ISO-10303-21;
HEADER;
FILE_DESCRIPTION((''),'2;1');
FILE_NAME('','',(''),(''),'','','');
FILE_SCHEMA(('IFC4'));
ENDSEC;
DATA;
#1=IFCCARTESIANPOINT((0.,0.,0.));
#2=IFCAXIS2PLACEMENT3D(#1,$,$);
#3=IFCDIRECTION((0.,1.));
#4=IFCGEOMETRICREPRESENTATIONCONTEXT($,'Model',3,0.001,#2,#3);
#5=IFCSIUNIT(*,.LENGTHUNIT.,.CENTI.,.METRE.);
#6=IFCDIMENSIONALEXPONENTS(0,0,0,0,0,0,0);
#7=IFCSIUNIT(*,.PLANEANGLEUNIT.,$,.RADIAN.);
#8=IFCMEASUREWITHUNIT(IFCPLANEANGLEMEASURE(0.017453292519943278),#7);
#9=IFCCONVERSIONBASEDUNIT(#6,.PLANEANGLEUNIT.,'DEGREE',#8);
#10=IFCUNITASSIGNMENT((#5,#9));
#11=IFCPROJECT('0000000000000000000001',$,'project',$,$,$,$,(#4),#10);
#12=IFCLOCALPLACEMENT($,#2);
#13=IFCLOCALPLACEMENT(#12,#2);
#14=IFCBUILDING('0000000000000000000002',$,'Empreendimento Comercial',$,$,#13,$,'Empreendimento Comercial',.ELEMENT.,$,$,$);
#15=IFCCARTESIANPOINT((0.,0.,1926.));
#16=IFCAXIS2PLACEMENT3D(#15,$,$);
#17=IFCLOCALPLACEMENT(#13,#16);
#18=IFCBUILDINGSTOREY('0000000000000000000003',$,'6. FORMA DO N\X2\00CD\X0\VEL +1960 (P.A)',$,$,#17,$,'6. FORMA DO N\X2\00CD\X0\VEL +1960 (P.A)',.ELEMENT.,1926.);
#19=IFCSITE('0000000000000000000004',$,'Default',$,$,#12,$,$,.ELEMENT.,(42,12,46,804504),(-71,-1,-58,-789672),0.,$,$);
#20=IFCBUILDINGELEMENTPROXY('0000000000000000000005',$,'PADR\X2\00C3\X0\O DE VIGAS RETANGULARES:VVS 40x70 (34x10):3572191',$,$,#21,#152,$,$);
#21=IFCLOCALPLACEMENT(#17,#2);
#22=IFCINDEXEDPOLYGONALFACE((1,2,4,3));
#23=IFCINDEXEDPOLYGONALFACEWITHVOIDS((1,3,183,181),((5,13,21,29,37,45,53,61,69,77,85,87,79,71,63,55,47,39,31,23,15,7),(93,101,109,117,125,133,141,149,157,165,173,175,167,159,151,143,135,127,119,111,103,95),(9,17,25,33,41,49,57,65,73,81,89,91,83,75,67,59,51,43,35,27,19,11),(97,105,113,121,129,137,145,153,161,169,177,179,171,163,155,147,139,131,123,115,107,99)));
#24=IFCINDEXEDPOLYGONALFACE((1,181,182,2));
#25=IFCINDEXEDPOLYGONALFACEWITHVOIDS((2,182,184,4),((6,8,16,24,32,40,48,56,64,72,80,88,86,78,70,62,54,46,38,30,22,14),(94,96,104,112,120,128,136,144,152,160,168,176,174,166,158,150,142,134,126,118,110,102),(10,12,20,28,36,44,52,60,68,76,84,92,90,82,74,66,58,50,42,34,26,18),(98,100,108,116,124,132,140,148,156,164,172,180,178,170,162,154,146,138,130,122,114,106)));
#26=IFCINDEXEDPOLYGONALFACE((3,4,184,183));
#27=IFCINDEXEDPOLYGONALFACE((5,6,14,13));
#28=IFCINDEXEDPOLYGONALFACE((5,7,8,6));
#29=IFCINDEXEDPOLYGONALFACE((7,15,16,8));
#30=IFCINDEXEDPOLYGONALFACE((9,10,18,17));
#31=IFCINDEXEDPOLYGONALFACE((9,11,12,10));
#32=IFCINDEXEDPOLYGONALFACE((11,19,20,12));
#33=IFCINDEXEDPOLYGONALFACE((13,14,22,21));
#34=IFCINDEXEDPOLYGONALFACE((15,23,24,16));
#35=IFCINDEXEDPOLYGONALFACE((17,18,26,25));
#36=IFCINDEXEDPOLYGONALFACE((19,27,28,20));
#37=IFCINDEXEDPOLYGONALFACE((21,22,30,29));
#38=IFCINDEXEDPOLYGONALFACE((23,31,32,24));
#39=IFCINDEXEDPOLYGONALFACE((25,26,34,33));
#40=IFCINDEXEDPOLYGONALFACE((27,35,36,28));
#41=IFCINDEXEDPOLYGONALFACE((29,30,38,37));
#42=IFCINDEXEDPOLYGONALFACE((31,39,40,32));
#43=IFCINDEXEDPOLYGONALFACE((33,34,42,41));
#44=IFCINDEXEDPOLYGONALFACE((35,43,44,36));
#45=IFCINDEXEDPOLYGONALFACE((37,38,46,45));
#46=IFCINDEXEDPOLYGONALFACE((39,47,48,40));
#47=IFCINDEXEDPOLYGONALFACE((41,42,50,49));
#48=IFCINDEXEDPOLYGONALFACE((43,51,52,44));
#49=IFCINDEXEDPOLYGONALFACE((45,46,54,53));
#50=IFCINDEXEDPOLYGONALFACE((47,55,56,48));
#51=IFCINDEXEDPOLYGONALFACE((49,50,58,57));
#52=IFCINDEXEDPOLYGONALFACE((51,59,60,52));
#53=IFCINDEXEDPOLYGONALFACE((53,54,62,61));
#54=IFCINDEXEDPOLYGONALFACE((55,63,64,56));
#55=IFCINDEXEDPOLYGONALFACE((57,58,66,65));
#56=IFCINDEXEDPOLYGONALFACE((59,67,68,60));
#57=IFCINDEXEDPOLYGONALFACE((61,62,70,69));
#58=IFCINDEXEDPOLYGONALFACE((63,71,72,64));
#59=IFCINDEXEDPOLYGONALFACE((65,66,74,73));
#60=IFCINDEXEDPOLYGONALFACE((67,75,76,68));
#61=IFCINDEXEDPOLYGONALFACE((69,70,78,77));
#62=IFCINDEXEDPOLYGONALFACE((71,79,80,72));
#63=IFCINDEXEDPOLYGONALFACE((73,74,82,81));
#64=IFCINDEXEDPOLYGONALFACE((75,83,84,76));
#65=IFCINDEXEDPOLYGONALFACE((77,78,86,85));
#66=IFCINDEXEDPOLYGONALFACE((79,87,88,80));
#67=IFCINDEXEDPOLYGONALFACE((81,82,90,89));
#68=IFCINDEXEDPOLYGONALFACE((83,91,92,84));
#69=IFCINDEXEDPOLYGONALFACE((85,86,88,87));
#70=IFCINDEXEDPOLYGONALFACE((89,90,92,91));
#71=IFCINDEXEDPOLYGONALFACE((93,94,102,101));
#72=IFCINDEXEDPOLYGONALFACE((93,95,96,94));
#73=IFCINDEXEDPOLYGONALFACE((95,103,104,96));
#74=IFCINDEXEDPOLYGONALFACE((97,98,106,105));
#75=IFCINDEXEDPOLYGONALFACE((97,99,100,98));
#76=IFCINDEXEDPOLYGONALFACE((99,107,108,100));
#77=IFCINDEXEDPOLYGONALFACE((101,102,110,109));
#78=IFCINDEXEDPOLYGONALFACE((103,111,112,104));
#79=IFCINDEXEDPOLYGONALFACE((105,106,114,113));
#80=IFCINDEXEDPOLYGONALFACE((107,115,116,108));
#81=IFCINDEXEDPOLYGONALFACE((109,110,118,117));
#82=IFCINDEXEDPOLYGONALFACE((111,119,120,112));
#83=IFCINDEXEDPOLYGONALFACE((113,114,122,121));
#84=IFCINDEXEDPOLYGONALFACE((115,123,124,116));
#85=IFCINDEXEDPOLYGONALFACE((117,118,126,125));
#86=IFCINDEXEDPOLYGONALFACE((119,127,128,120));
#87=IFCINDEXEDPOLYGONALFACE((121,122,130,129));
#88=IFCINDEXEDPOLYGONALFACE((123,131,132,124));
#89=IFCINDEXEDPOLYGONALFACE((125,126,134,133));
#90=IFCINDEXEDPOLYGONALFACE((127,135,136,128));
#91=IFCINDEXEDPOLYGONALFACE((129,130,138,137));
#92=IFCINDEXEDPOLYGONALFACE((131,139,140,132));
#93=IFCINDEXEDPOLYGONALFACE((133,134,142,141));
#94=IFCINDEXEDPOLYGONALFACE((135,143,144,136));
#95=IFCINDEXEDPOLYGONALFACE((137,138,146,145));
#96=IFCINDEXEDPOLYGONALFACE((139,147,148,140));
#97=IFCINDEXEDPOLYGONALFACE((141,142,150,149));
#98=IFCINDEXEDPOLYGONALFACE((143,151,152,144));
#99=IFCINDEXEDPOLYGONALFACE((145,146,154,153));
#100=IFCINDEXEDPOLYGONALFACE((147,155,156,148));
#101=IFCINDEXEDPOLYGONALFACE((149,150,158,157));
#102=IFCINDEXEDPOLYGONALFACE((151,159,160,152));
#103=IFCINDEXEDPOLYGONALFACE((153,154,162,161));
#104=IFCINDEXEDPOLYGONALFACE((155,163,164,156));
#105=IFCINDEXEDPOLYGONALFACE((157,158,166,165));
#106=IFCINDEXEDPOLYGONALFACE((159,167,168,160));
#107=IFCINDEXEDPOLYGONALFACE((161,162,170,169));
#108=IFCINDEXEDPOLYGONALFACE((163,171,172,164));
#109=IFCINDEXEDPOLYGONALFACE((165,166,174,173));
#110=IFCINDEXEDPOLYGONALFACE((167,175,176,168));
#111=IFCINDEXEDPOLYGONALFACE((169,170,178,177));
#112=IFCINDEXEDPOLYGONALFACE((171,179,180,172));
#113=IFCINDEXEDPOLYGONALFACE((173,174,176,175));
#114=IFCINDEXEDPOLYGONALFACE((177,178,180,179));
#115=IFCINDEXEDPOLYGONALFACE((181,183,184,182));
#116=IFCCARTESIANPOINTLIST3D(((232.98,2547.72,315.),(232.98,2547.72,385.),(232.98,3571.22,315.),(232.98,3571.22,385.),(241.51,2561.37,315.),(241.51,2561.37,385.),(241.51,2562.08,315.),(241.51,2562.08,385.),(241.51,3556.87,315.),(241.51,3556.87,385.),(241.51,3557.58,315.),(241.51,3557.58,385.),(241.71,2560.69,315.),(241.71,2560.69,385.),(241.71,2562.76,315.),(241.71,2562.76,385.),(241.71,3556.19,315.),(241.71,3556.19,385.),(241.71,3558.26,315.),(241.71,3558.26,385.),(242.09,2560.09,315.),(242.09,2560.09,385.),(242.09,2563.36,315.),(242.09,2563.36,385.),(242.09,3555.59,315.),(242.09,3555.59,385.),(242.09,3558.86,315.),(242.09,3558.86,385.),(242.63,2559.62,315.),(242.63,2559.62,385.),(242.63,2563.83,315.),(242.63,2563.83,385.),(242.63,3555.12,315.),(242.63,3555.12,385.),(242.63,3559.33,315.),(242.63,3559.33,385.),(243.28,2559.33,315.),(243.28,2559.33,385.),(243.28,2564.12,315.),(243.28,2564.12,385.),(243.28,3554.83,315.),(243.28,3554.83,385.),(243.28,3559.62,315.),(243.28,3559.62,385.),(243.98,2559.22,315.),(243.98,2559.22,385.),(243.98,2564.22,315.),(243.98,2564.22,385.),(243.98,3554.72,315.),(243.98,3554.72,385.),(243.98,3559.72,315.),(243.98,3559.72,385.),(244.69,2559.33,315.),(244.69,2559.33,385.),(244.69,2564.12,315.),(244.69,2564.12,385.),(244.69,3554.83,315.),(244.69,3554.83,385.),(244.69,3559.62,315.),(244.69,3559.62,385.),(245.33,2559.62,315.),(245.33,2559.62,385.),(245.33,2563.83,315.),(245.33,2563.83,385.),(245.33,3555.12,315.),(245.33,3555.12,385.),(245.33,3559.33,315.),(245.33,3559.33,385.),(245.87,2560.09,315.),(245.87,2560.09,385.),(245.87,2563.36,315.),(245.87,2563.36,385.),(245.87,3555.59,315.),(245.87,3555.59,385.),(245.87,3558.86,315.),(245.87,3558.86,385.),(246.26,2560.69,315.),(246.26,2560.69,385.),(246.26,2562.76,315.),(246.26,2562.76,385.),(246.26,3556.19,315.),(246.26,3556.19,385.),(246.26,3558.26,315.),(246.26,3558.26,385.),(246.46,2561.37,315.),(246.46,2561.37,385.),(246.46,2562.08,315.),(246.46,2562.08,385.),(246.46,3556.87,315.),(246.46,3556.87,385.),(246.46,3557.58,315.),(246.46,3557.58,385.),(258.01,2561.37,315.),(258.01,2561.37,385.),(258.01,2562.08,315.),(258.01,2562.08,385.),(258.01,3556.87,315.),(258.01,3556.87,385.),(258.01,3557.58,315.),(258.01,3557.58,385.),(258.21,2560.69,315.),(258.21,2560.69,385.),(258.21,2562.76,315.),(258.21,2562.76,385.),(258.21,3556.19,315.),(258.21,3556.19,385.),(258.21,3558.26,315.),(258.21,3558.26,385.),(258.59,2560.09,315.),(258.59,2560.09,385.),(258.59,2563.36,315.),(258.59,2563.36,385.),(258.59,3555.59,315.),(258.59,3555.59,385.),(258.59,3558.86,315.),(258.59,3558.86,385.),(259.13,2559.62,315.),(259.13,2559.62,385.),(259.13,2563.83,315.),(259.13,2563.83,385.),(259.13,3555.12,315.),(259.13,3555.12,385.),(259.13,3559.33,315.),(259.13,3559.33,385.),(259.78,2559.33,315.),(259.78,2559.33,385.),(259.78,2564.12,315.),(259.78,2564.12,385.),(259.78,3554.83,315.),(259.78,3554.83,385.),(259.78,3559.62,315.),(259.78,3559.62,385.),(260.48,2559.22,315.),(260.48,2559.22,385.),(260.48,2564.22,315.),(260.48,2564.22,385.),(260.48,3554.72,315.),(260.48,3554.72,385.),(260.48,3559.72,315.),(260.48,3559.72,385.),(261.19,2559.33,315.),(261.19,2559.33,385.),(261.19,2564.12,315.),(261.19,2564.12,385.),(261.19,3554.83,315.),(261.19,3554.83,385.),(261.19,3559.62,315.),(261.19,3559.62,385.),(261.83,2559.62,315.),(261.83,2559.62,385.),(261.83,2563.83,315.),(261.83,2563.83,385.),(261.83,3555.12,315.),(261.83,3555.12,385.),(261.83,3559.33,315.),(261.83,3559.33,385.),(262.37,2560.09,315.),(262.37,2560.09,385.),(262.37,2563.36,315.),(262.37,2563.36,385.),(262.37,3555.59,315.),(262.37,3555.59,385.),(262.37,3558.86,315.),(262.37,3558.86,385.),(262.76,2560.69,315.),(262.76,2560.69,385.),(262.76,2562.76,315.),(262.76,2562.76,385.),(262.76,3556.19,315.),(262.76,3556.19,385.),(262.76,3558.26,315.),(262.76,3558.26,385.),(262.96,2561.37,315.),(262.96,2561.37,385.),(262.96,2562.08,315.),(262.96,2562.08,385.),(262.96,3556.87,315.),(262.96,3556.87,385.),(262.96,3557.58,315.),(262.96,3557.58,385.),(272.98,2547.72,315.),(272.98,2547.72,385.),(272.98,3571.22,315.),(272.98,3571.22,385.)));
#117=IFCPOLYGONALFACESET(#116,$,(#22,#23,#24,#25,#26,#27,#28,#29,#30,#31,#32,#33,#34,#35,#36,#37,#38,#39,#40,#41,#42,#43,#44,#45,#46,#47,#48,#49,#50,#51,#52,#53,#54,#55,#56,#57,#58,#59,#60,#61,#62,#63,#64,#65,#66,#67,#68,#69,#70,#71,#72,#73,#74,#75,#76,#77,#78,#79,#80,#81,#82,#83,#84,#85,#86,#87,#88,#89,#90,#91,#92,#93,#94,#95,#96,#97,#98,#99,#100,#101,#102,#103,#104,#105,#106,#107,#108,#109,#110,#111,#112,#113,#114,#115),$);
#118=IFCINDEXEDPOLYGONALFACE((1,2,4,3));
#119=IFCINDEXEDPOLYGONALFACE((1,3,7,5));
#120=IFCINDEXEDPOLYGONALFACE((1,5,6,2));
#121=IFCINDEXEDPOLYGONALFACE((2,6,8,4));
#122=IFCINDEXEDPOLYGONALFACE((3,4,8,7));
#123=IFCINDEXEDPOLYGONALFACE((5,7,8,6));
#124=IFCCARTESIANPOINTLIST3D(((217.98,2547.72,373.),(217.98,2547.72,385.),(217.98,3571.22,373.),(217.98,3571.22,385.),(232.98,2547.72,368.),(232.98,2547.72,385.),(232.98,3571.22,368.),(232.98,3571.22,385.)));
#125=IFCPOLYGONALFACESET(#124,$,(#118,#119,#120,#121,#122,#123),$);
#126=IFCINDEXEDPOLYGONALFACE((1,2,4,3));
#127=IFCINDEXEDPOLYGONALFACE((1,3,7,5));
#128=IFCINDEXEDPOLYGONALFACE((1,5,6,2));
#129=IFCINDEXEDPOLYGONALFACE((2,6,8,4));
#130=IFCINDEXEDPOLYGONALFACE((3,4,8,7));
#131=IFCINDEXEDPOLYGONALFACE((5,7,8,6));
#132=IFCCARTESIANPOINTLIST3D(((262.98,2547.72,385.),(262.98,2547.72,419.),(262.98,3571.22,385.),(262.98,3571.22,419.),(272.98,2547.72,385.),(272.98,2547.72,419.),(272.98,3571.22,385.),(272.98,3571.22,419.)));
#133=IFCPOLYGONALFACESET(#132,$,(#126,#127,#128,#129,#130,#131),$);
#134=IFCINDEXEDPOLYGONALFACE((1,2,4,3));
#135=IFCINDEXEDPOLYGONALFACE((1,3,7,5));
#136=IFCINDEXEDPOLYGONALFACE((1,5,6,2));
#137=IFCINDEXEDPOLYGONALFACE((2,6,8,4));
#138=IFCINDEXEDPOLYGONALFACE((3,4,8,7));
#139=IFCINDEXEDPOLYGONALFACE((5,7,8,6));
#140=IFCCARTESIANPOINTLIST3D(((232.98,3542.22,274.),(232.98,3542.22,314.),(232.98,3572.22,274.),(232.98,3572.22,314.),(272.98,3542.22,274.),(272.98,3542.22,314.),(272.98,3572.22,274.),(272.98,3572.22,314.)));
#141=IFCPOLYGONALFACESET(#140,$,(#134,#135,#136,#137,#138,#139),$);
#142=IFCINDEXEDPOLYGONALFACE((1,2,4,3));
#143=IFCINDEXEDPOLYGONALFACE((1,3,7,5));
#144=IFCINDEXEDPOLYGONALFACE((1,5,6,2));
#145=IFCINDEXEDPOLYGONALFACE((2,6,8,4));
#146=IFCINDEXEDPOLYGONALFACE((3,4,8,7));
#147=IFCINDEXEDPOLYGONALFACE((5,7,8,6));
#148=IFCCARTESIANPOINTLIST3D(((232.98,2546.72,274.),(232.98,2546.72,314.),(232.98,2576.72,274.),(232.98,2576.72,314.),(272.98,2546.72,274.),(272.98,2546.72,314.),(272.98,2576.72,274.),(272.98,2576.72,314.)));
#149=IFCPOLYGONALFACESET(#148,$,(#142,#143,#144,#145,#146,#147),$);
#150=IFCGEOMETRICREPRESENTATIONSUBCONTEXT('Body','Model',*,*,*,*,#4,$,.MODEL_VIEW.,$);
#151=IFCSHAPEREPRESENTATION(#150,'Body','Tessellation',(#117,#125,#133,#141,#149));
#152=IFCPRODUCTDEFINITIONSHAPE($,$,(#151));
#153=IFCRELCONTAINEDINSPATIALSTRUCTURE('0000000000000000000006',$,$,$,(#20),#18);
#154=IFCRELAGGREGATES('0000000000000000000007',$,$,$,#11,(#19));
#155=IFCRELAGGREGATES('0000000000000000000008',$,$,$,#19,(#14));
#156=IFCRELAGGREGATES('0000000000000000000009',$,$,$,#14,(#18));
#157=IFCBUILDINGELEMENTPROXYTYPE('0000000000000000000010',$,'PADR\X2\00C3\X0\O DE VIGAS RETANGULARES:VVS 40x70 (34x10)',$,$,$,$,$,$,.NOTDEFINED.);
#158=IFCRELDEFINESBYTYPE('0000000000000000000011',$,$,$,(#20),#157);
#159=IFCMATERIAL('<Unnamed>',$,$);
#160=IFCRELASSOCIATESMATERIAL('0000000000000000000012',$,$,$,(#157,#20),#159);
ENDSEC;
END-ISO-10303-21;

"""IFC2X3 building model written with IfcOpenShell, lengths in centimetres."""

from ifc_helpers import new_model, entity, si_unit, converted_unit, direction, frame, frame_2d, origin, place, context, subcontext, project, spatial, polyline, circle_curve, parameter, trimmed, segment, composite_curve, rectangle, outline, extrude, source, transform, mapped, material, type_object, type_shapes, element, save


model = new_model("IFC2X3")

# Units and contexts
model_context = context("Model", 3, precision=0.001, world=origin(), true_north=direction((0.0, 1.0)))
body_context = subcontext(model_context, "Body", "Model", "MODEL_VIEW")
ifc_project = project(units=[si_unit("LENGTHUNIT", "METRE", prefix="CENTI"), converted_unit("PLANEANGLEUNIT", "DEGREE", entity("IfcPlaneAngleMeasure", 0.017453292519943278), si_unit("PLANEANGLEUNIT", "RADIAN"), dimensions=[0, 0, 0, 0, 0, 0, 0])], contexts=[model_context])

# Site, building, storey
site_placement = place(None, origin())
site = spatial("IfcSite", under=ifc_project, at=site_placement, Name="Default", CompositionType="ELEMENT", RefLatitude=(42, 12, 46, 804504), RefLongitude=(-71, -1, -58, -789672), RefElevation=0.0)
building_placement = place(site_placement, origin())
building = spatial("IfcBuilding", under=site, at=building_placement, Name="Empreendimento Comercial", LongName="Empreendimento Comercial", CompositionType="ELEMENT")
storey_placement = place(building_placement, frame((0.0, 0.0, 1926.0)))
storey = spatial("IfcBuildingStorey", under=building, at=storey_placement, Name="6. FORMA DO NÍVEL +1960 (P.A)", LongName="6. FORMA DO NÍVEL +1960 (P.A)", CompositionType="ELEMENT", Elevation=1926.0)

# Building element proxy
ifc_material = material(Name="<Unnamed>")
building_element_proxy_type_1 = type_object("IfcBuildingElementProxyType", Name="PADRÃO DE VIGAS RETANGULARES:VVS 40x70 (34x10)", PredefinedType="NOTDEFINED", material=ifc_material)
shared_shape_1 = source(origin(), body_context, "Body", "SweptSolid", [
    extrude(outline(polyline([(-511.75, -20.0), (511.75, -20.0), (511.75, 20.0), (-511.75, 20.0), (-511.75, -20.0)]), holes=[composite_curve([segment(trimmed(circle_curve(frame_2d((-497.75, -7.5), x_axis=(-1.0, 0.0)), 2.5), [parameter(0.0)], [parameter(180.0)], True, "PARAMETER"), False, "CONTINUOUS"), segment(trimmed(circle_curve(frame_2d((-497.75, -7.5), x_axis=(-1.0, 0.0)), 2.5), [parameter(180.0)], [parameter(0.0)], True, "PARAMETER"), False, "CONTINUOUS")], self_intersect=False), composite_curve([segment(trimmed(circle_curve(frame_2d((-497.75, 9.0), x_axis=(-1.0, 0.0)), 2.5), [parameter(0.0)], [parameter(180.0)], True, "PARAMETER"), False, "CONTINUOUS"), segment(trimmed(circle_curve(frame_2d((-497.75, 9.0), x_axis=(-1.0, 0.0)), 2.5), [parameter(180.0)], [parameter(0.0)], True, "PARAMETER"), False, "CONTINUOUS")], self_intersect=False), composite_curve([segment(trimmed(circle_curve(frame_2d((497.75, 9.0), x_axis=(-1.0, 0.0)), 2.5), [parameter(0.0)], [parameter(180.0)], True, "PARAMETER"), False, "CONTINUOUS"), segment(trimmed(circle_curve(frame_2d((497.75, 9.0), x_axis=(-1.0, 0.0)), 2.5), [parameter(180.0)], [parameter(0.0)], True, "PARAMETER"), False, "CONTINUOUS")], self_intersect=False), composite_curve([segment(trimmed(circle_curve(frame_2d((497.75, -7.5), x_axis=(-1.0, 0.0)), 2.5), [parameter(0.0)], [parameter(180.0)], True, "PARAMETER"), False, "CONTINUOUS"), segment(trimmed(circle_curve(frame_2d((497.75, -7.5), x_axis=(-1.0, 0.0)), 2.5), [parameter(180.0)], [parameter(0.0)], True, "PARAMETER"), False, "CONTINUOUS")], self_intersect=False)]), frame((252.98, 3059.47, 2241.0), z_axis=(0.0, 0.0, 1.0), x_axis=(0.0, 1.0, 0.0)), (0.0, 0.0, 1.0), 70.0),
    extrude(outline(polyline([(-7.5, -7.25), (7.5, -7.25), (7.5, 9.75), (-7.5, 4.75), (-7.5, -7.25)])), frame((225.48, 2547.72, 2303.75), z_axis=(0.0, 1.0, 0.0), x_axis=(1.0, 0.0, 0.0)), (0.0, 0.0, 1.0), 1023.5),
    extrude(rectangle(XDim=1023.5, YDim=10.0, at=frame_2d((0.0, 0.0), x_axis=(1.0, 0.0))), frame((267.98, 3059.47, 2311.0), z_axis=(0.0, 0.0, 1.0), x_axis=(0.0, 1.0, 0.0)), (0.0, 0.0, 1.0), 34.0),
    extrude(rectangle(XDim=40.0, YDim=30.0, at=frame_2d((0.0, 0.0), x_axis=(1.0, 0.0))), frame((252.98, 3557.22, 2200.0)), (0.0, 0.0, 1.0), 40.0),
    extrude(rectangle(XDim=40.0, YDim=30.0, at=frame_2d((0.0, 0.0), x_axis=(1.0, 0.0))), frame((252.98, 2561.72, 2200.0)), (0.0, 0.0, 1.0), 40.0),
])
type_shapes(building_element_proxy_type_1, [shared_shape_1])
proxy_1_placement = place(storey_placement, frame((0.0, 0.0, -1926.0)))
element("IfcBuildingElementProxy", 1, at=proxy_1_placement, inside=storey, type_object=building_element_proxy_type_1, material=ifc_material, Name="PADRÃO DE VIGAS RETANGULARES:VVS 40x70 (34x10):3572191", context=body_context, shape_type="MappedRepresentation", body=[
    mapped(shared_shape_1, transform((0.0, 0.0, 0.0), scale=1.0)),
])

save(model, "model.ifc")
